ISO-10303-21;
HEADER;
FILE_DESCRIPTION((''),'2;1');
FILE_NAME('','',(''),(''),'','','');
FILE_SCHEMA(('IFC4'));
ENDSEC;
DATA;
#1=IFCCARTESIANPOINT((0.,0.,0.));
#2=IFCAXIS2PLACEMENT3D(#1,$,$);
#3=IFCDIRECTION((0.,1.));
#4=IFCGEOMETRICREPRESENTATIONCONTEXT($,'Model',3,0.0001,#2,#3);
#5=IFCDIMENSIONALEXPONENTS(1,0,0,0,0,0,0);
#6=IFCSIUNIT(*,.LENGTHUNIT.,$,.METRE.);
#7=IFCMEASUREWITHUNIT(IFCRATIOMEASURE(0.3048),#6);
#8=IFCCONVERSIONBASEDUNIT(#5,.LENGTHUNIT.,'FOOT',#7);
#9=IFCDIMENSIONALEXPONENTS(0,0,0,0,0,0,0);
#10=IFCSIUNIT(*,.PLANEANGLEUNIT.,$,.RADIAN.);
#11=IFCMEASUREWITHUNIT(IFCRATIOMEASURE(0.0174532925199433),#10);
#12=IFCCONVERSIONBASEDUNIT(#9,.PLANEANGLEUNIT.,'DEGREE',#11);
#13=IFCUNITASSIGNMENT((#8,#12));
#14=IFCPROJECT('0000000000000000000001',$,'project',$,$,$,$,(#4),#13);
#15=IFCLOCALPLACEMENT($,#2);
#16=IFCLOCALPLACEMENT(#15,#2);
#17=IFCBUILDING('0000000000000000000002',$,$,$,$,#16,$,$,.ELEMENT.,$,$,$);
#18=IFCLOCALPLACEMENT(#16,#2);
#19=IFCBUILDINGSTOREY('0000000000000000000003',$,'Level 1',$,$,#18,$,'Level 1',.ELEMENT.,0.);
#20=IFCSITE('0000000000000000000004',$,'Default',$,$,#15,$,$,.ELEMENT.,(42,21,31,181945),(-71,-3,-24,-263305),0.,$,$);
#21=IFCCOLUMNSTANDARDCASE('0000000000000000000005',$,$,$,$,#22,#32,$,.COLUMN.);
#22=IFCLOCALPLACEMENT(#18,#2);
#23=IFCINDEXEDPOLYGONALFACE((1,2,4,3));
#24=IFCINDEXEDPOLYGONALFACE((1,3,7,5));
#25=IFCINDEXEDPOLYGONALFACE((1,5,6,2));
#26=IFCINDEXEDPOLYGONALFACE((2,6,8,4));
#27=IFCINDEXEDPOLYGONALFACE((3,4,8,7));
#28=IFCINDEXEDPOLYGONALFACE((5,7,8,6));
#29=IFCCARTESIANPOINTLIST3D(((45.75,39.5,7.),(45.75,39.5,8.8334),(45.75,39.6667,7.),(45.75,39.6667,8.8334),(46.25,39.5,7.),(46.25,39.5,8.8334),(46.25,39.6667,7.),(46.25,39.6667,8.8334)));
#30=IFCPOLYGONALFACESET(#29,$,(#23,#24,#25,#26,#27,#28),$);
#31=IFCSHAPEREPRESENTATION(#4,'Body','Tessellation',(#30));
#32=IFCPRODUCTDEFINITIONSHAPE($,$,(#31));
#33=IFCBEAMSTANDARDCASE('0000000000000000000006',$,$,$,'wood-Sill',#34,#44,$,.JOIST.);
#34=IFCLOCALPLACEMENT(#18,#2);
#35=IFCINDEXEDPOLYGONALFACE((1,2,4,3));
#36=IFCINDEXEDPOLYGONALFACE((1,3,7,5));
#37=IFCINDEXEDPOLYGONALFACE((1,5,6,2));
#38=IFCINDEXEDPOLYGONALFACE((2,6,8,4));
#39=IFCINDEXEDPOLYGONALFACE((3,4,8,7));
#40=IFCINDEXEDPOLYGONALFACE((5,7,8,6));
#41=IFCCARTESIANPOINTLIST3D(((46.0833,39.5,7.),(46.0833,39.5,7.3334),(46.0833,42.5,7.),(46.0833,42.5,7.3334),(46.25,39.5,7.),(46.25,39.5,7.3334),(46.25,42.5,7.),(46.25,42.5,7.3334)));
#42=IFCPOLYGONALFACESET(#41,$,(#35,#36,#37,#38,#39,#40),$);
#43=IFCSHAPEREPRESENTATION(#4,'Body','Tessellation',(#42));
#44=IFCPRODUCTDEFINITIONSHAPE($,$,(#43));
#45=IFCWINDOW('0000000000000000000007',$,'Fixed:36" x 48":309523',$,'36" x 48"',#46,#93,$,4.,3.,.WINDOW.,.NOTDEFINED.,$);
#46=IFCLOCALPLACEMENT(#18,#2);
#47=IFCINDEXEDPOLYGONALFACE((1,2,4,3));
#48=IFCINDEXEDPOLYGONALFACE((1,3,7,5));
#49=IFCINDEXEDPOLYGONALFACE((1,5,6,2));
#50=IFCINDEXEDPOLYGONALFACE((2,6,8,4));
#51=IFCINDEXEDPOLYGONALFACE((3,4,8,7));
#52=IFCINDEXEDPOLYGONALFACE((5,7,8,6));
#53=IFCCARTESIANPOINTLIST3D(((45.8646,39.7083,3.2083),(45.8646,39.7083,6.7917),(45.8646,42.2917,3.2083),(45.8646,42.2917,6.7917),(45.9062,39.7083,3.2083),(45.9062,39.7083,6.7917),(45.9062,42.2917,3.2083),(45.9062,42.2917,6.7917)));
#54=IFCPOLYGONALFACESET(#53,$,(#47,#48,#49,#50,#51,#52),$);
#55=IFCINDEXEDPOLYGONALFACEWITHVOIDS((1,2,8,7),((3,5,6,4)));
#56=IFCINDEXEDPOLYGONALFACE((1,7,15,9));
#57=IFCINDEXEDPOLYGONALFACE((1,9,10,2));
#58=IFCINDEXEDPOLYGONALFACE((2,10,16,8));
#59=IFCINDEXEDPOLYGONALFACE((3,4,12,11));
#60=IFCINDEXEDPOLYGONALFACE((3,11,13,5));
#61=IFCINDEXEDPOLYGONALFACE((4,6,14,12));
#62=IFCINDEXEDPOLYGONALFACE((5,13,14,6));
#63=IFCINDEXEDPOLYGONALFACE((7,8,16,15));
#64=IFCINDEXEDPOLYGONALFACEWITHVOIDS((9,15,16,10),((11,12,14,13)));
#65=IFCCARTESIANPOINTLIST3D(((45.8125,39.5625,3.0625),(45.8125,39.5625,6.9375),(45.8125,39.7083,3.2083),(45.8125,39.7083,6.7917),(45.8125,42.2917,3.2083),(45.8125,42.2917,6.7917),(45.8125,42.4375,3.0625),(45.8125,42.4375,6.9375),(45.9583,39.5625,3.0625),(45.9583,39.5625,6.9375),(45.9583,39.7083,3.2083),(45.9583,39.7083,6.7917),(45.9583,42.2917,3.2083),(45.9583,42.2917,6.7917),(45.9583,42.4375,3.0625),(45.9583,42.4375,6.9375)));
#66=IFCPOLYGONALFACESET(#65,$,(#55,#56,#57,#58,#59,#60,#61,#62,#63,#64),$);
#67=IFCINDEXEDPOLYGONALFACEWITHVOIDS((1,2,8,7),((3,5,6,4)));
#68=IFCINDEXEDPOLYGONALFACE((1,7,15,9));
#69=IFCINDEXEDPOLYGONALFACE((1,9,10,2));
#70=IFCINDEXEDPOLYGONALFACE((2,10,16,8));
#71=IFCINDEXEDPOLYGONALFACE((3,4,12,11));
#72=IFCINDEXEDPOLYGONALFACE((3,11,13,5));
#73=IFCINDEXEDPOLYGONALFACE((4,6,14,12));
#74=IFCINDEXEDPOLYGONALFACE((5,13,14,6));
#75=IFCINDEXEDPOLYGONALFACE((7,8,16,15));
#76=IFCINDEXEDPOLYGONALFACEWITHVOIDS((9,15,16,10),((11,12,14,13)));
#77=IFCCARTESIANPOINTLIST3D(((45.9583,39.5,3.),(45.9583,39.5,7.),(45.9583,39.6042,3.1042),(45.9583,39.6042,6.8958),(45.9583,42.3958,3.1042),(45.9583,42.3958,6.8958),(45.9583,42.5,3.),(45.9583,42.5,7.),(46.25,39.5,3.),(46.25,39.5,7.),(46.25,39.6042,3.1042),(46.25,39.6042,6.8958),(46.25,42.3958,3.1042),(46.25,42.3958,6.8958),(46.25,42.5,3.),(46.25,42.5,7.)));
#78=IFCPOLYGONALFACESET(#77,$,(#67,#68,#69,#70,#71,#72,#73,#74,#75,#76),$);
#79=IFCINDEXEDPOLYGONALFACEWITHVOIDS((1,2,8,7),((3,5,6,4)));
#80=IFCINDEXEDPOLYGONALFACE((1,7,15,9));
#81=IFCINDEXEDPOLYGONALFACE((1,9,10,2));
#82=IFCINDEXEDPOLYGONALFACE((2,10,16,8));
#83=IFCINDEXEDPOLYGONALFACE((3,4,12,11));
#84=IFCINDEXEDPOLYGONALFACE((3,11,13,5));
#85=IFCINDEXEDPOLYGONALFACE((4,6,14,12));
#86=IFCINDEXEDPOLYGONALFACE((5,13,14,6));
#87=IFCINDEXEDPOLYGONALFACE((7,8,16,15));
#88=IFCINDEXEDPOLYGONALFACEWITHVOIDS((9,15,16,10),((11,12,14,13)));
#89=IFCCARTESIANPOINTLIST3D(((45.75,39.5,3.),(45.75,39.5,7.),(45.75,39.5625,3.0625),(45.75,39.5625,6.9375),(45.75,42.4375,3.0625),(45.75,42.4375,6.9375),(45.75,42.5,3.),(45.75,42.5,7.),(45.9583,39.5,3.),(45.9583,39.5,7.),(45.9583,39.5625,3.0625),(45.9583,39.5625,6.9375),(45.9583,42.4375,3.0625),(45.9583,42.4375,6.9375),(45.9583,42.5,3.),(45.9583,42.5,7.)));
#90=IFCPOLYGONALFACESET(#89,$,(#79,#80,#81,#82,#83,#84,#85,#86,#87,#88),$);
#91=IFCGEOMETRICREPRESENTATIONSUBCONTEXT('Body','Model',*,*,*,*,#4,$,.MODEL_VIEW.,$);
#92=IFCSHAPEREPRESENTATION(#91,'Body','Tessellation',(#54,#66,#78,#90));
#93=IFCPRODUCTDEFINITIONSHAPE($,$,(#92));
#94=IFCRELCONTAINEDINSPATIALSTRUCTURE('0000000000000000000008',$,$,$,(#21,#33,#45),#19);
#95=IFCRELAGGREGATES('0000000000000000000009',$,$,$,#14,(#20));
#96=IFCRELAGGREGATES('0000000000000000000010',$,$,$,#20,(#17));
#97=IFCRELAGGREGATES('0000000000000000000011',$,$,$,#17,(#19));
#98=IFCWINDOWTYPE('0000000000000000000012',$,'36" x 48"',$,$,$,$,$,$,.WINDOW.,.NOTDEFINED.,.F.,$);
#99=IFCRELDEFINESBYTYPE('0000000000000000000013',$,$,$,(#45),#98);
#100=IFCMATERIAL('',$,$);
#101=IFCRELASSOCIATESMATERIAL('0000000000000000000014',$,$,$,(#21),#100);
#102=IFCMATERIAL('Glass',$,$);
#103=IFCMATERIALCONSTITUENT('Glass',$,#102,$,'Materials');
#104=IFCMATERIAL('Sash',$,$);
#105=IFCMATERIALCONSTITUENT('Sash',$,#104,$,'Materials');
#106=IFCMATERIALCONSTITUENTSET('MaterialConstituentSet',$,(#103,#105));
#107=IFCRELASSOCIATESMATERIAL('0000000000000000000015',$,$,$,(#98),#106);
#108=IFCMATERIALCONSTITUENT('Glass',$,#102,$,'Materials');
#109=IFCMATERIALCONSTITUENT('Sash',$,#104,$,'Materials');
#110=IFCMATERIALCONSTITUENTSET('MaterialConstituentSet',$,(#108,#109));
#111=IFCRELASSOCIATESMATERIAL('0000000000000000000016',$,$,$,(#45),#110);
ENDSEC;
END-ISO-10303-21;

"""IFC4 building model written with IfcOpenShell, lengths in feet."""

from ifc_helpers import new_model, entity, si_unit, converted_unit, direction, frame, frame_2d, origin, origin_with_axes, place, context, subcontext, project, spatial, polyline, rectangle, outline, extrude, source, transform, mapped, material, constituent, constituent_set, type_object, type_shapes, element, save


model = new_model("IFC4")

# Units and contexts
model_context = context("Model", 3, precision=0.0001, world=origin(), true_north=direction((0.0, 1.0)))
body_context = subcontext(model_context, "Body", "Model", "MODEL_VIEW")
ifc_project = project(units=[converted_unit("LENGTHUNIT", "FOOT", entity("IfcRatioMeasure", 0.3048), si_unit("LENGTHUNIT", "METRE"), dimensions=[1, 0, 0, 0, 0, 0, 0]), converted_unit("PLANEANGLEUNIT", "DEGREE", entity("IfcRatioMeasure", 0.0174532925199433), si_unit("PLANEANGLEUNIT", "RADIAN"), dimensions=[0, 0, 0, 0, 0, 0, 0])], contexts=[model_context])

# Site, building, storey
site_placement = place(None, origin())
site = spatial("IfcSite", under=ifc_project, at=site_placement, Name="Default", CompositionType="ELEMENT", RefLatitude=(42, 21, 31, 181945), RefLongitude=(-71, -3, -24, -263305), RefElevation=0.0)
building_placement = place(site_placement, origin())
building = spatial("IfcBuilding", under=site, at=building_placement, CompositionType="ELEMENT")
storey_placement = place(building_placement, origin())
storey = spatial("IfcBuildingStorey", under=building, at=storey_placement, Name="Level 1", LongName="Level 1", CompositionType="ELEMENT", Elevation=0.0)

# Column
placement_1 = place(storey_placement, frame((46.0, 46.25, 0.0), z_axis=(0.0, 0.0, 1.0), x_axis=(0.0, -1.0, 0.0)))
ifc_material_1 = material(Name="")
for number, where, z_axis, x_axis in (
    (1, (6.6667, 0.0, 7.0), (0.0, 0.0, 1.0), (1.0, 0.0, 0.0)),
):
    element("IfcColumnStandardCase", number, at=place(placement_1, frame(where, z_axis=z_axis, x_axis=x_axis)), inside=storey, material=ifc_material_1, PredefinedType="COLUMN", context=model_context, shape_type="SweptSolid", body=[
        extrude(rectangle(XDim=0.1667, YDim=0.5), origin(), (0.0, 0.0, 1.0), 1.8334),
    ])

# Beam
for number, where, z_axis, x_axis in (
    (2, (3.75, 0.1667, 7.1667), (1.0, 0.0, 0.0), (0.0, 0.0, 1.0)),
):
    element("IfcBeamStandardCase", number, at=place(placement_1, frame(where, z_axis=z_axis, x_axis=x_axis)), inside=storey, ObjectType="wood-Sill", PredefinedType="JOIST", context=model_context, shape_type="SweptSolid", body=[
        extrude(rectangle(XDim=0.3333, YDim=0.1667), origin_with_axes(), (0.0, 0.0, 1.0), 3.0),
    ])

# Window
ifc_material_2 = material(Name="Glass")
ifc_constituent_1 = constituent(ifc_material_2, Name="Glass", Category="Materials")
ifc_material_3 = material(Name="Sash")
ifc_constituent_2 = constituent(ifc_material_3, Name="Sash", Category="Materials")
ifc_constituent_set_1 = constituent_set(constituents=[ifc_constituent_1, ifc_constituent_2], Name="MaterialConstituentSet")
ifc_constituent_3 = constituent(ifc_material_2, Name="Glass", Category="Materials")
ifc_constituent_4 = constituent(ifc_material_3, Name="Sash", Category="Materials")
ifc_constituent_set_2 = constituent_set(constituents=[ifc_constituent_3, ifc_constituent_4], Name="MaterialConstituentSet")
window_type = type_object("IfcWindowType", Name="36\" x 48\"", ParameterTakesPrecedence=False, PartitioningType="NOTDEFINED", PredefinedType="WINDOW", material=ifc_constituent_set_2)
shared_shape = source(origin(), body_context, "Body", "SweptSolid", [
    extrude(rectangle(XDim=0.0417, YDim=2.5833, at=frame_2d((0.0, 0.0), x_axis=(1.0, 0.0))), frame((1.5, 0.3646, 0.2083), z_axis=(0.0, 0.0, 1.0), x_axis=(0.0, 1.0, 0.0)), (0.0, 0.0, 1.0), 3.5833),
    extrude(outline(polyline([(-1.4375, -1.9375), (1.4375, -1.9375), (1.4375, 1.9375), (-1.4375, 1.9375), (-1.4375, -1.9375)]), holes=[polyline([(-1.2917, -1.7917), (-1.2917, 1.7917), (1.2917, 1.7917), (1.2917, -1.7917), (-1.2917, -1.7917)])]), frame((1.5, 0.2917, 2.0), z_axis=(0.0, 1.0, 0.0), x_axis=(1.0, 0.0, 0.0)), (0.0, 0.0, 1.0), 0.1458),
    extrude(outline(polyline([(-1.5, -2.0), (1.5, -2.0), (1.5, 2.0), (-1.5, 2.0), (-1.5, -2.0)]), holes=[polyline([(-1.3958, -1.8958), (-1.3958, 1.8958), (1.3958, 1.8958), (1.3958, -1.8958), (-1.3958, -1.8958)])]), frame((1.5, 0.0, 2.0), z_axis=(0.0, 1.0, 0.0), x_axis=(1.0, 0.0, 0.0)), (0.0, 0.0, 1.0), 0.2917),
    extrude(outline(polyline([(-2.0, -1.5), (2.0, -1.5), (2.0, 1.5), (-2.0, 1.5), (-2.0, -1.5)]), holes=[polyline([(-1.9375, -1.4375), (-1.9375, 1.4375), (1.9375, 1.4375), (1.9375, -1.4375), (-1.9375, -1.4375)])]), frame((1.5, 0.2917, 2.0), z_axis=(0.0, 1.0, 0.0), x_axis=(0.0, 0.0, -1.0)), (0.0, 0.0, 1.0), 0.2083),
])
type_shapes(window_type, [shared_shape])
placement_2 = place(placement_1, frame((6.75, 0.25, 3.0)))
window_placement = place(placement_2, frame((0.0, 0.0, 0.0), z_axis=(0.0, 0.0, 1.0), x_axis=(-1.0, 0.0, 0.0)))
element("IfcWindow", 3, at=window_placement, inside=storey, type_object=window_type, material=ifc_constituent_set_1, Name="Fixed:36\" x 48\":309523", ObjectType="36\" x 48\"", OverallHeight=4.0, OverallWidth=3.0, PartitioningType="NOTDEFINED", PredefinedType="WINDOW", context=body_context, shape_type="MappedRepresentation", body=[
    mapped(shared_shape, transform((0.0, 0.0, 0.0), scale=1.0)),
])

save(model, "model.ifc")
